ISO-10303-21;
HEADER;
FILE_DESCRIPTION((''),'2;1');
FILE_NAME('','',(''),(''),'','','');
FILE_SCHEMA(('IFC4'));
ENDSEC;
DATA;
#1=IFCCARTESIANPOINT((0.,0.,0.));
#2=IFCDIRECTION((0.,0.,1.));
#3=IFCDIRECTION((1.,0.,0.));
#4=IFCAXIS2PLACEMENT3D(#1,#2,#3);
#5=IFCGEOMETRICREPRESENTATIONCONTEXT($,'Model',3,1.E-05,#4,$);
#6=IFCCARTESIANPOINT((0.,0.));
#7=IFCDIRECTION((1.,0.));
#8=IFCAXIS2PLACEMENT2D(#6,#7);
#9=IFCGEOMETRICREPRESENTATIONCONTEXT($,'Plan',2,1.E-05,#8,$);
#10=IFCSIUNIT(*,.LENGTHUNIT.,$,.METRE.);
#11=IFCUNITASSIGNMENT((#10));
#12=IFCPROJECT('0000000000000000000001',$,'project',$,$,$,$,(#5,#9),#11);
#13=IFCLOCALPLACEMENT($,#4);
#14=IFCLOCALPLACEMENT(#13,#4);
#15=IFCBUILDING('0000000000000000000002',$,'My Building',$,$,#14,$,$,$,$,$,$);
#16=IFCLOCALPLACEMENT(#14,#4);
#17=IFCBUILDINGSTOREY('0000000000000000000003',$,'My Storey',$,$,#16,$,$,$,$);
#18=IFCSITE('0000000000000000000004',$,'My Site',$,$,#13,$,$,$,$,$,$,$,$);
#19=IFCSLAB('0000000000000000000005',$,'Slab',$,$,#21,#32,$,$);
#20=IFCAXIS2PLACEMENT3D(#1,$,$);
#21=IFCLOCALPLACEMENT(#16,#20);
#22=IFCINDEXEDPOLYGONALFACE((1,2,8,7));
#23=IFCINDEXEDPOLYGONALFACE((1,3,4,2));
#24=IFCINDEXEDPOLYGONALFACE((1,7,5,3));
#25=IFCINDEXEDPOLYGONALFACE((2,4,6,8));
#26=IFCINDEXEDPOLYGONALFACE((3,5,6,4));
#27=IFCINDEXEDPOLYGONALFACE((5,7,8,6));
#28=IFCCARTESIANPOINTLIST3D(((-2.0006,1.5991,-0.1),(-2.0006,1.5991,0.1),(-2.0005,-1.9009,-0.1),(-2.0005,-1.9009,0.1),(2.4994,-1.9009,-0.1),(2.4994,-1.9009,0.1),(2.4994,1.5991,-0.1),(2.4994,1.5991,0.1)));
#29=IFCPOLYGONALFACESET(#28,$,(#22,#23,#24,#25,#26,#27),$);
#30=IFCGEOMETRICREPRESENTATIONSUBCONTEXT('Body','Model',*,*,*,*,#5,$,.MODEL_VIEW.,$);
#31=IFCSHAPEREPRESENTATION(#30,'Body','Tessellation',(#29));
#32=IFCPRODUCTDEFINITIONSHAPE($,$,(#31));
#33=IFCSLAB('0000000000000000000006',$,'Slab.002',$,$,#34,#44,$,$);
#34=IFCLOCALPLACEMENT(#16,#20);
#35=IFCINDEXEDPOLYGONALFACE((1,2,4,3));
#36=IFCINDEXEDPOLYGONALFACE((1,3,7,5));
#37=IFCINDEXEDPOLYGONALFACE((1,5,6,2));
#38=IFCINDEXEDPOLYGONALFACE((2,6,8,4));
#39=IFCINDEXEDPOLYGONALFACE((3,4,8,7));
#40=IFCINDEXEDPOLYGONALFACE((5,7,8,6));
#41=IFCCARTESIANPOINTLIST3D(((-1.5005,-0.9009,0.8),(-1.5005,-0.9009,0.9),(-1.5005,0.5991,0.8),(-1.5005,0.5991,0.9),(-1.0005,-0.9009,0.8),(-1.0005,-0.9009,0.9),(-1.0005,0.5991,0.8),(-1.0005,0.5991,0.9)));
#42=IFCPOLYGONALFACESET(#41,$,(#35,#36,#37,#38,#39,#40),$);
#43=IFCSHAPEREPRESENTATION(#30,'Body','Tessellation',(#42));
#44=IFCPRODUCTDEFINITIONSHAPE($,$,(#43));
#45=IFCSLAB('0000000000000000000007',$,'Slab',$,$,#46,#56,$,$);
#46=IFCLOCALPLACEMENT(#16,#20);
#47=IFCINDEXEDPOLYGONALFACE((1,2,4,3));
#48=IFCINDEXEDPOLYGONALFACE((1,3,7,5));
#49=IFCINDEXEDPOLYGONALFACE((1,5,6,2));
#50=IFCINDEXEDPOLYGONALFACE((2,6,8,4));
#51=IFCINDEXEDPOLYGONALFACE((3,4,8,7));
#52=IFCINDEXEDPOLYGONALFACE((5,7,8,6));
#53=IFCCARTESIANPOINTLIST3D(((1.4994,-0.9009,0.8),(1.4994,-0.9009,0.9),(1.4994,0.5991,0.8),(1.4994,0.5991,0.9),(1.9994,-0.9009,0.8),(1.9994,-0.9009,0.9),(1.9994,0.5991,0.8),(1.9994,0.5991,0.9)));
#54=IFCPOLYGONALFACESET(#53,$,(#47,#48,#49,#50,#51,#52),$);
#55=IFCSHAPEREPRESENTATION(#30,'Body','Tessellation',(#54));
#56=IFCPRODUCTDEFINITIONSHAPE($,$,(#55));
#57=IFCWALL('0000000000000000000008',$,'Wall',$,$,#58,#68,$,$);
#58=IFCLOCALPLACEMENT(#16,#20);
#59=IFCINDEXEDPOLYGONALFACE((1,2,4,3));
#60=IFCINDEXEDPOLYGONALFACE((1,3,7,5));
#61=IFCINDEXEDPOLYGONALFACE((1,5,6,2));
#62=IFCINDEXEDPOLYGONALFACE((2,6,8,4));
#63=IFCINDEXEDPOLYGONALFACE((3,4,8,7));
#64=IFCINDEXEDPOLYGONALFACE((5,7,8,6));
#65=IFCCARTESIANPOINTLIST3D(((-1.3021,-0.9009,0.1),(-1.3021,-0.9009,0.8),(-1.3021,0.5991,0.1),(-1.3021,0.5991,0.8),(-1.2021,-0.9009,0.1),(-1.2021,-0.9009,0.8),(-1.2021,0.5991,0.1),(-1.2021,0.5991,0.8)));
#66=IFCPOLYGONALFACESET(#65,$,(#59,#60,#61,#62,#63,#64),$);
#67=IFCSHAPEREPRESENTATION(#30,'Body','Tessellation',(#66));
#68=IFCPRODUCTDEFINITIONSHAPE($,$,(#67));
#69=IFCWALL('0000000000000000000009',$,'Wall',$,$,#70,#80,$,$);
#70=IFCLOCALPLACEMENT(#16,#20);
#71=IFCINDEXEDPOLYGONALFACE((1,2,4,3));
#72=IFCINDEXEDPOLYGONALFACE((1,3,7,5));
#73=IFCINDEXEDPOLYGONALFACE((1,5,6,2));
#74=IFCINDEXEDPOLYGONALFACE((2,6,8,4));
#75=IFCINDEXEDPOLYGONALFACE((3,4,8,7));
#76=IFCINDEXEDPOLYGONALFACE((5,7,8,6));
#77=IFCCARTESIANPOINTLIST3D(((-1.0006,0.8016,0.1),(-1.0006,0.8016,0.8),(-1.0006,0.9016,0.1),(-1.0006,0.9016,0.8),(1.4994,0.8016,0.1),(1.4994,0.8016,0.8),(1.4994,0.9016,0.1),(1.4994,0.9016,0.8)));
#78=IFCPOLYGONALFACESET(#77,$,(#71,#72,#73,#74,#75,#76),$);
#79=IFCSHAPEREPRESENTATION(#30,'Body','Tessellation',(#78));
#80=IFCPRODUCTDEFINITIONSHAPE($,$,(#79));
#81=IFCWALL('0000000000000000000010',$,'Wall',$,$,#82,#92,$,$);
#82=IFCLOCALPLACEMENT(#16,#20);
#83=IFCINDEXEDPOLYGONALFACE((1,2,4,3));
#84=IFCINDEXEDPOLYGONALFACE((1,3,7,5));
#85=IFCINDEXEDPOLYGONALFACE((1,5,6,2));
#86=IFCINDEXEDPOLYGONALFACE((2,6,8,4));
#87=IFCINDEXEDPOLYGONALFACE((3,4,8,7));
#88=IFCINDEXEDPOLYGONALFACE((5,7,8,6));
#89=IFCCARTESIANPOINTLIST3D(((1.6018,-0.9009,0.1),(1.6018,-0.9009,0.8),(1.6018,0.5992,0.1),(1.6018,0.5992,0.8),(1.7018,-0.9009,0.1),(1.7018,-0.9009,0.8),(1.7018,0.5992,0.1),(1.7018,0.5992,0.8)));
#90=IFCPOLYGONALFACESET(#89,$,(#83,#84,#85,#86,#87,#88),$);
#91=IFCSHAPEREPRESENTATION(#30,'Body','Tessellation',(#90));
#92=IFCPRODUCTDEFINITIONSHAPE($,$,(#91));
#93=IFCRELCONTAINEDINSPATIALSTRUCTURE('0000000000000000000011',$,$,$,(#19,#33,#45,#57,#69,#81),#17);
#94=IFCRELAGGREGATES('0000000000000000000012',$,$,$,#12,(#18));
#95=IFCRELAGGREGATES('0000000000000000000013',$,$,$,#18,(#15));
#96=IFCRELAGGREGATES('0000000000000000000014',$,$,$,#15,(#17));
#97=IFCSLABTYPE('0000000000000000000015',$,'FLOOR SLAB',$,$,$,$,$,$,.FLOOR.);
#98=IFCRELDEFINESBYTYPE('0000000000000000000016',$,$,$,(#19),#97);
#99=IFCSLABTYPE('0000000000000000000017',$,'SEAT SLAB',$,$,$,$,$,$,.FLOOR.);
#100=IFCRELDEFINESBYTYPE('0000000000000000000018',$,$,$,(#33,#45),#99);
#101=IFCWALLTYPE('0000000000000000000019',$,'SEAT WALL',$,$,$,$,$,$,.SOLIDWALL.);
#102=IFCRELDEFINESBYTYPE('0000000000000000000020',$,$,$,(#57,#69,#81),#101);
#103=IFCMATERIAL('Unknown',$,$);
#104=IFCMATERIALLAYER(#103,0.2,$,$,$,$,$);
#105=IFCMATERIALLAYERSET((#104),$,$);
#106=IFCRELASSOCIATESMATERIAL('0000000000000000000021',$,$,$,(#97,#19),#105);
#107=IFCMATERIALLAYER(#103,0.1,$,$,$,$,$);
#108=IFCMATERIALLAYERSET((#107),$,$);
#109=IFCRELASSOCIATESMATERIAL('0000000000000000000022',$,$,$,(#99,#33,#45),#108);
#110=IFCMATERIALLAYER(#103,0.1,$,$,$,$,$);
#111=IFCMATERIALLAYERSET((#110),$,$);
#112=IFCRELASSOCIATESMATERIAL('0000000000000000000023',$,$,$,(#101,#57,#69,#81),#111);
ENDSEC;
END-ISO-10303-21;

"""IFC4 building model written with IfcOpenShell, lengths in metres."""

from ifc_helpers import new_model, si_unit, frame, origin_with_axes, origin_2d_with_axis, place, context, subcontext, project, spatial, line, indexed_curve, outline, extrude, material, layer, layer_set, layer_usage, type_object, element, save


model = new_model("IFC4")

# Units and contexts
model_context = context("Model", 3, precision=1e-05, world=origin_with_axes())
plan_context = context("Plan", 2, precision=1e-05, world=origin_2d_with_axis())
body_context = subcontext(model_context, "Body", "Model", "MODEL_VIEW")
ifc_project = project(units=[si_unit("LENGTHUNIT", "METRE")], contexts=[model_context, plan_context])

# Site, building, storey
site_placement = place(None, origin_with_axes())
site = spatial("IfcSite", under=ifc_project, at=site_placement, Name="My Site")
building_placement = place(site_placement, origin_with_axes())
building = spatial("IfcBuilding", under=site, at=building_placement, Name="My Building")
storey_placement = place(building_placement, origin_with_axes())
storey = spatial("IfcBuildingStorey", under=building, at=storey_placement, Name="My Storey")

# Slabs
ifc_material = material(Name="Unknown")
ifc_layer_1 = layer(ifc_material, 0.2)
ifc_layer_set_1 = layer_set([ifc_layer_1])
ifc_layer_usage_1 = layer_usage(ifc_layer_set_1, "AXIS3", "POSITIVE", -0.2)
slab_type_1 = type_object("IfcSlabType", Name="FLOOR SLAB", PredefinedType="FLOOR", material=ifc_layer_set_1)
slab_1_placement = place(storey_placement, frame((-2.0006, 1.5991, 0.1), z_axis=(0.0, 0.0, 1.0), x_axis=(1.0, 0.0, 0.0)))
element("IfcSlab", 1, at=slab_1_placement, inside=storey, type_object=slab_type_1, material=ifc_layer_usage_1, Name="Slab", context=body_context, shape_type="SweptSolid", body=[
    extrude(outline(indexed_curve([(0.0, 0.0), (4.5, 0.0), (4.5, -3.5), (0.0, -3.5), (0.0, 0.0)])), frame((0.0, 0.0, -0.2), z_axis=(0.0, 0.0, 1.0), x_axis=(1.0, 0.0, 0.0)), (0.0, 0.0, 1.0), 0.2),
])
ifc_layer_2 = layer(ifc_material, 0.1)
ifc_layer_set_2 = layer_set([ifc_layer_2])
ifc_layer_usage_2 = layer_usage(ifc_layer_set_2, "AXIS3", "POSITIVE", -0.2)
slab_type_2 = type_object("IfcSlabType", Name="SEAT SLAB", PredefinedType="FLOOR", material=ifc_layer_set_2)
slab_2_placement = place(storey_placement, frame((-1.5005, -0.9009, 1.0), z_axis=(0.0, 0.0, 1.0), x_axis=(1.0, 0.0, 0.0)))
element("IfcSlab", 2, at=slab_2_placement, inside=storey, type_object=slab_type_2, material=ifc_layer_usage_2, Name="Slab.002", context=body_context, shape_type="SweptSolid", body=[
    extrude(outline(indexed_curve([(0.0, 0.0), (0.0, 1.5), (0.5, 1.5), (0.5, 0.0), (0.0, 0.0)])), frame((0.0, 0.0, -0.2), z_axis=(0.0, 0.0, 1.0), x_axis=(1.0, 0.0, 0.0)), (0.0, 0.0, 1.0), 0.1),
])
ifc_layer_usage_3 = layer_usage(ifc_layer_set_2, "AXIS3", "POSITIVE", -0.2)
slab_3_placement = place(storey_placement, frame((1.4994, -0.9009, 1.0), z_axis=(0.0, 0.0, 1.0), x_axis=(1.0, 0.0, 0.0)))
element("IfcSlab", 3, at=slab_3_placement, inside=storey, type_object=slab_type_2, material=ifc_layer_usage_3, Name="Slab", context=body_context, shape_type="SweptSolid", body=[
    extrude(outline(indexed_curve([(0.0, 0.0), (0.5, 0.0), (0.5, 1.5), (0.0, 1.5), (0.0, 0.0)])), frame((0.0, 0.0, -0.2), z_axis=(0.0, 0.0, 1.0), x_axis=(1.0, 0.0, 0.0)), (0.0, 0.0, 1.0), 0.1),
])

# Walls
ifc_layer_3 = layer(ifc_material, 0.1)
ifc_layer_set_3 = layer_set([ifc_layer_3])
ifc_layer_usage_4 = layer_usage(ifc_layer_set_3, "AXIS2", "POSITIVE", 0.0)
wall_type = type_object("IfcWallType", Name="SEAT WALL", PredefinedType="SOLIDWALL", material=ifc_layer_set_3)
wall_1_placement = place(storey_placement, frame((-1.3021, 0.5991, 0.1), z_axis=(0.0, 0.0, 1.0), x_axis=(0.0, -1.0, 0.0)))
element("IfcWall", 4, at=wall_1_placement, inside=storey, type_object=wall_type, material=ifc_layer_usage_4, Name="Wall", context=body_context, shape_type="SweptSolid", body=[
    extrude(outline(indexed_curve([(0.0, 0.0), (0.0, 0.1), (1.5, 0.1), (1.5, 0.0)], segments=[line(1, 2, 3, 4, 1)])), origin_with_axes(), (0.0, 0.0, 1.0), 0.7),
])
ifc_layer_usage_5 = layer_usage(ifc_layer_set_3, "AXIS2", "POSITIVE", 0.0)
wall_2_placement = place(storey_placement, frame((1.4994, 0.9016, 0.1), z_axis=(0.0, 0.0, 1.0), x_axis=(-1.0, 0.0, 0.0)))
element("IfcWall", 5, at=wall_2_placement, inside=storey, type_object=wall_type, material=ifc_layer_usage_5, Name="Wall", context=body_context, shape_type="SweptSolid", body=[
    extrude(outline(indexed_curve([(0.0, 0.0), (0.0, 0.1), (2.5, 0.1), (2.5, 0.0)], segments=[line(1, 2, 3, 4, 1)])), origin_with_axes(), (0.0, 0.0, 1.0), 0.7),
])
ifc_layer_usage_6 = layer_usage(ifc_layer_set_3, "AXIS2", "POSITIVE", 0.0)
wall_3_placement = place(storey_placement, frame((1.6018, 0.5992, 0.1), z_axis=(0.0, 0.0, 1.0), x_axis=(0.0, -1.0, 0.0)))
element("IfcWall", 6, at=wall_3_placement, inside=storey, type_object=wall_type, material=ifc_layer_usage_6, Name="Wall", context=body_context, shape_type="SweptSolid", body=[
    extrude(outline(indexed_curve([(0.0, 0.0), (0.0, 0.1), (1.5, 0.1), (1.5, 0.0)], segments=[line(1, 2, 3, 4, 1)])), origin_with_axes(), (0.0, 0.0, 1.0), 0.7),
])

save(model, "model.ifc")
